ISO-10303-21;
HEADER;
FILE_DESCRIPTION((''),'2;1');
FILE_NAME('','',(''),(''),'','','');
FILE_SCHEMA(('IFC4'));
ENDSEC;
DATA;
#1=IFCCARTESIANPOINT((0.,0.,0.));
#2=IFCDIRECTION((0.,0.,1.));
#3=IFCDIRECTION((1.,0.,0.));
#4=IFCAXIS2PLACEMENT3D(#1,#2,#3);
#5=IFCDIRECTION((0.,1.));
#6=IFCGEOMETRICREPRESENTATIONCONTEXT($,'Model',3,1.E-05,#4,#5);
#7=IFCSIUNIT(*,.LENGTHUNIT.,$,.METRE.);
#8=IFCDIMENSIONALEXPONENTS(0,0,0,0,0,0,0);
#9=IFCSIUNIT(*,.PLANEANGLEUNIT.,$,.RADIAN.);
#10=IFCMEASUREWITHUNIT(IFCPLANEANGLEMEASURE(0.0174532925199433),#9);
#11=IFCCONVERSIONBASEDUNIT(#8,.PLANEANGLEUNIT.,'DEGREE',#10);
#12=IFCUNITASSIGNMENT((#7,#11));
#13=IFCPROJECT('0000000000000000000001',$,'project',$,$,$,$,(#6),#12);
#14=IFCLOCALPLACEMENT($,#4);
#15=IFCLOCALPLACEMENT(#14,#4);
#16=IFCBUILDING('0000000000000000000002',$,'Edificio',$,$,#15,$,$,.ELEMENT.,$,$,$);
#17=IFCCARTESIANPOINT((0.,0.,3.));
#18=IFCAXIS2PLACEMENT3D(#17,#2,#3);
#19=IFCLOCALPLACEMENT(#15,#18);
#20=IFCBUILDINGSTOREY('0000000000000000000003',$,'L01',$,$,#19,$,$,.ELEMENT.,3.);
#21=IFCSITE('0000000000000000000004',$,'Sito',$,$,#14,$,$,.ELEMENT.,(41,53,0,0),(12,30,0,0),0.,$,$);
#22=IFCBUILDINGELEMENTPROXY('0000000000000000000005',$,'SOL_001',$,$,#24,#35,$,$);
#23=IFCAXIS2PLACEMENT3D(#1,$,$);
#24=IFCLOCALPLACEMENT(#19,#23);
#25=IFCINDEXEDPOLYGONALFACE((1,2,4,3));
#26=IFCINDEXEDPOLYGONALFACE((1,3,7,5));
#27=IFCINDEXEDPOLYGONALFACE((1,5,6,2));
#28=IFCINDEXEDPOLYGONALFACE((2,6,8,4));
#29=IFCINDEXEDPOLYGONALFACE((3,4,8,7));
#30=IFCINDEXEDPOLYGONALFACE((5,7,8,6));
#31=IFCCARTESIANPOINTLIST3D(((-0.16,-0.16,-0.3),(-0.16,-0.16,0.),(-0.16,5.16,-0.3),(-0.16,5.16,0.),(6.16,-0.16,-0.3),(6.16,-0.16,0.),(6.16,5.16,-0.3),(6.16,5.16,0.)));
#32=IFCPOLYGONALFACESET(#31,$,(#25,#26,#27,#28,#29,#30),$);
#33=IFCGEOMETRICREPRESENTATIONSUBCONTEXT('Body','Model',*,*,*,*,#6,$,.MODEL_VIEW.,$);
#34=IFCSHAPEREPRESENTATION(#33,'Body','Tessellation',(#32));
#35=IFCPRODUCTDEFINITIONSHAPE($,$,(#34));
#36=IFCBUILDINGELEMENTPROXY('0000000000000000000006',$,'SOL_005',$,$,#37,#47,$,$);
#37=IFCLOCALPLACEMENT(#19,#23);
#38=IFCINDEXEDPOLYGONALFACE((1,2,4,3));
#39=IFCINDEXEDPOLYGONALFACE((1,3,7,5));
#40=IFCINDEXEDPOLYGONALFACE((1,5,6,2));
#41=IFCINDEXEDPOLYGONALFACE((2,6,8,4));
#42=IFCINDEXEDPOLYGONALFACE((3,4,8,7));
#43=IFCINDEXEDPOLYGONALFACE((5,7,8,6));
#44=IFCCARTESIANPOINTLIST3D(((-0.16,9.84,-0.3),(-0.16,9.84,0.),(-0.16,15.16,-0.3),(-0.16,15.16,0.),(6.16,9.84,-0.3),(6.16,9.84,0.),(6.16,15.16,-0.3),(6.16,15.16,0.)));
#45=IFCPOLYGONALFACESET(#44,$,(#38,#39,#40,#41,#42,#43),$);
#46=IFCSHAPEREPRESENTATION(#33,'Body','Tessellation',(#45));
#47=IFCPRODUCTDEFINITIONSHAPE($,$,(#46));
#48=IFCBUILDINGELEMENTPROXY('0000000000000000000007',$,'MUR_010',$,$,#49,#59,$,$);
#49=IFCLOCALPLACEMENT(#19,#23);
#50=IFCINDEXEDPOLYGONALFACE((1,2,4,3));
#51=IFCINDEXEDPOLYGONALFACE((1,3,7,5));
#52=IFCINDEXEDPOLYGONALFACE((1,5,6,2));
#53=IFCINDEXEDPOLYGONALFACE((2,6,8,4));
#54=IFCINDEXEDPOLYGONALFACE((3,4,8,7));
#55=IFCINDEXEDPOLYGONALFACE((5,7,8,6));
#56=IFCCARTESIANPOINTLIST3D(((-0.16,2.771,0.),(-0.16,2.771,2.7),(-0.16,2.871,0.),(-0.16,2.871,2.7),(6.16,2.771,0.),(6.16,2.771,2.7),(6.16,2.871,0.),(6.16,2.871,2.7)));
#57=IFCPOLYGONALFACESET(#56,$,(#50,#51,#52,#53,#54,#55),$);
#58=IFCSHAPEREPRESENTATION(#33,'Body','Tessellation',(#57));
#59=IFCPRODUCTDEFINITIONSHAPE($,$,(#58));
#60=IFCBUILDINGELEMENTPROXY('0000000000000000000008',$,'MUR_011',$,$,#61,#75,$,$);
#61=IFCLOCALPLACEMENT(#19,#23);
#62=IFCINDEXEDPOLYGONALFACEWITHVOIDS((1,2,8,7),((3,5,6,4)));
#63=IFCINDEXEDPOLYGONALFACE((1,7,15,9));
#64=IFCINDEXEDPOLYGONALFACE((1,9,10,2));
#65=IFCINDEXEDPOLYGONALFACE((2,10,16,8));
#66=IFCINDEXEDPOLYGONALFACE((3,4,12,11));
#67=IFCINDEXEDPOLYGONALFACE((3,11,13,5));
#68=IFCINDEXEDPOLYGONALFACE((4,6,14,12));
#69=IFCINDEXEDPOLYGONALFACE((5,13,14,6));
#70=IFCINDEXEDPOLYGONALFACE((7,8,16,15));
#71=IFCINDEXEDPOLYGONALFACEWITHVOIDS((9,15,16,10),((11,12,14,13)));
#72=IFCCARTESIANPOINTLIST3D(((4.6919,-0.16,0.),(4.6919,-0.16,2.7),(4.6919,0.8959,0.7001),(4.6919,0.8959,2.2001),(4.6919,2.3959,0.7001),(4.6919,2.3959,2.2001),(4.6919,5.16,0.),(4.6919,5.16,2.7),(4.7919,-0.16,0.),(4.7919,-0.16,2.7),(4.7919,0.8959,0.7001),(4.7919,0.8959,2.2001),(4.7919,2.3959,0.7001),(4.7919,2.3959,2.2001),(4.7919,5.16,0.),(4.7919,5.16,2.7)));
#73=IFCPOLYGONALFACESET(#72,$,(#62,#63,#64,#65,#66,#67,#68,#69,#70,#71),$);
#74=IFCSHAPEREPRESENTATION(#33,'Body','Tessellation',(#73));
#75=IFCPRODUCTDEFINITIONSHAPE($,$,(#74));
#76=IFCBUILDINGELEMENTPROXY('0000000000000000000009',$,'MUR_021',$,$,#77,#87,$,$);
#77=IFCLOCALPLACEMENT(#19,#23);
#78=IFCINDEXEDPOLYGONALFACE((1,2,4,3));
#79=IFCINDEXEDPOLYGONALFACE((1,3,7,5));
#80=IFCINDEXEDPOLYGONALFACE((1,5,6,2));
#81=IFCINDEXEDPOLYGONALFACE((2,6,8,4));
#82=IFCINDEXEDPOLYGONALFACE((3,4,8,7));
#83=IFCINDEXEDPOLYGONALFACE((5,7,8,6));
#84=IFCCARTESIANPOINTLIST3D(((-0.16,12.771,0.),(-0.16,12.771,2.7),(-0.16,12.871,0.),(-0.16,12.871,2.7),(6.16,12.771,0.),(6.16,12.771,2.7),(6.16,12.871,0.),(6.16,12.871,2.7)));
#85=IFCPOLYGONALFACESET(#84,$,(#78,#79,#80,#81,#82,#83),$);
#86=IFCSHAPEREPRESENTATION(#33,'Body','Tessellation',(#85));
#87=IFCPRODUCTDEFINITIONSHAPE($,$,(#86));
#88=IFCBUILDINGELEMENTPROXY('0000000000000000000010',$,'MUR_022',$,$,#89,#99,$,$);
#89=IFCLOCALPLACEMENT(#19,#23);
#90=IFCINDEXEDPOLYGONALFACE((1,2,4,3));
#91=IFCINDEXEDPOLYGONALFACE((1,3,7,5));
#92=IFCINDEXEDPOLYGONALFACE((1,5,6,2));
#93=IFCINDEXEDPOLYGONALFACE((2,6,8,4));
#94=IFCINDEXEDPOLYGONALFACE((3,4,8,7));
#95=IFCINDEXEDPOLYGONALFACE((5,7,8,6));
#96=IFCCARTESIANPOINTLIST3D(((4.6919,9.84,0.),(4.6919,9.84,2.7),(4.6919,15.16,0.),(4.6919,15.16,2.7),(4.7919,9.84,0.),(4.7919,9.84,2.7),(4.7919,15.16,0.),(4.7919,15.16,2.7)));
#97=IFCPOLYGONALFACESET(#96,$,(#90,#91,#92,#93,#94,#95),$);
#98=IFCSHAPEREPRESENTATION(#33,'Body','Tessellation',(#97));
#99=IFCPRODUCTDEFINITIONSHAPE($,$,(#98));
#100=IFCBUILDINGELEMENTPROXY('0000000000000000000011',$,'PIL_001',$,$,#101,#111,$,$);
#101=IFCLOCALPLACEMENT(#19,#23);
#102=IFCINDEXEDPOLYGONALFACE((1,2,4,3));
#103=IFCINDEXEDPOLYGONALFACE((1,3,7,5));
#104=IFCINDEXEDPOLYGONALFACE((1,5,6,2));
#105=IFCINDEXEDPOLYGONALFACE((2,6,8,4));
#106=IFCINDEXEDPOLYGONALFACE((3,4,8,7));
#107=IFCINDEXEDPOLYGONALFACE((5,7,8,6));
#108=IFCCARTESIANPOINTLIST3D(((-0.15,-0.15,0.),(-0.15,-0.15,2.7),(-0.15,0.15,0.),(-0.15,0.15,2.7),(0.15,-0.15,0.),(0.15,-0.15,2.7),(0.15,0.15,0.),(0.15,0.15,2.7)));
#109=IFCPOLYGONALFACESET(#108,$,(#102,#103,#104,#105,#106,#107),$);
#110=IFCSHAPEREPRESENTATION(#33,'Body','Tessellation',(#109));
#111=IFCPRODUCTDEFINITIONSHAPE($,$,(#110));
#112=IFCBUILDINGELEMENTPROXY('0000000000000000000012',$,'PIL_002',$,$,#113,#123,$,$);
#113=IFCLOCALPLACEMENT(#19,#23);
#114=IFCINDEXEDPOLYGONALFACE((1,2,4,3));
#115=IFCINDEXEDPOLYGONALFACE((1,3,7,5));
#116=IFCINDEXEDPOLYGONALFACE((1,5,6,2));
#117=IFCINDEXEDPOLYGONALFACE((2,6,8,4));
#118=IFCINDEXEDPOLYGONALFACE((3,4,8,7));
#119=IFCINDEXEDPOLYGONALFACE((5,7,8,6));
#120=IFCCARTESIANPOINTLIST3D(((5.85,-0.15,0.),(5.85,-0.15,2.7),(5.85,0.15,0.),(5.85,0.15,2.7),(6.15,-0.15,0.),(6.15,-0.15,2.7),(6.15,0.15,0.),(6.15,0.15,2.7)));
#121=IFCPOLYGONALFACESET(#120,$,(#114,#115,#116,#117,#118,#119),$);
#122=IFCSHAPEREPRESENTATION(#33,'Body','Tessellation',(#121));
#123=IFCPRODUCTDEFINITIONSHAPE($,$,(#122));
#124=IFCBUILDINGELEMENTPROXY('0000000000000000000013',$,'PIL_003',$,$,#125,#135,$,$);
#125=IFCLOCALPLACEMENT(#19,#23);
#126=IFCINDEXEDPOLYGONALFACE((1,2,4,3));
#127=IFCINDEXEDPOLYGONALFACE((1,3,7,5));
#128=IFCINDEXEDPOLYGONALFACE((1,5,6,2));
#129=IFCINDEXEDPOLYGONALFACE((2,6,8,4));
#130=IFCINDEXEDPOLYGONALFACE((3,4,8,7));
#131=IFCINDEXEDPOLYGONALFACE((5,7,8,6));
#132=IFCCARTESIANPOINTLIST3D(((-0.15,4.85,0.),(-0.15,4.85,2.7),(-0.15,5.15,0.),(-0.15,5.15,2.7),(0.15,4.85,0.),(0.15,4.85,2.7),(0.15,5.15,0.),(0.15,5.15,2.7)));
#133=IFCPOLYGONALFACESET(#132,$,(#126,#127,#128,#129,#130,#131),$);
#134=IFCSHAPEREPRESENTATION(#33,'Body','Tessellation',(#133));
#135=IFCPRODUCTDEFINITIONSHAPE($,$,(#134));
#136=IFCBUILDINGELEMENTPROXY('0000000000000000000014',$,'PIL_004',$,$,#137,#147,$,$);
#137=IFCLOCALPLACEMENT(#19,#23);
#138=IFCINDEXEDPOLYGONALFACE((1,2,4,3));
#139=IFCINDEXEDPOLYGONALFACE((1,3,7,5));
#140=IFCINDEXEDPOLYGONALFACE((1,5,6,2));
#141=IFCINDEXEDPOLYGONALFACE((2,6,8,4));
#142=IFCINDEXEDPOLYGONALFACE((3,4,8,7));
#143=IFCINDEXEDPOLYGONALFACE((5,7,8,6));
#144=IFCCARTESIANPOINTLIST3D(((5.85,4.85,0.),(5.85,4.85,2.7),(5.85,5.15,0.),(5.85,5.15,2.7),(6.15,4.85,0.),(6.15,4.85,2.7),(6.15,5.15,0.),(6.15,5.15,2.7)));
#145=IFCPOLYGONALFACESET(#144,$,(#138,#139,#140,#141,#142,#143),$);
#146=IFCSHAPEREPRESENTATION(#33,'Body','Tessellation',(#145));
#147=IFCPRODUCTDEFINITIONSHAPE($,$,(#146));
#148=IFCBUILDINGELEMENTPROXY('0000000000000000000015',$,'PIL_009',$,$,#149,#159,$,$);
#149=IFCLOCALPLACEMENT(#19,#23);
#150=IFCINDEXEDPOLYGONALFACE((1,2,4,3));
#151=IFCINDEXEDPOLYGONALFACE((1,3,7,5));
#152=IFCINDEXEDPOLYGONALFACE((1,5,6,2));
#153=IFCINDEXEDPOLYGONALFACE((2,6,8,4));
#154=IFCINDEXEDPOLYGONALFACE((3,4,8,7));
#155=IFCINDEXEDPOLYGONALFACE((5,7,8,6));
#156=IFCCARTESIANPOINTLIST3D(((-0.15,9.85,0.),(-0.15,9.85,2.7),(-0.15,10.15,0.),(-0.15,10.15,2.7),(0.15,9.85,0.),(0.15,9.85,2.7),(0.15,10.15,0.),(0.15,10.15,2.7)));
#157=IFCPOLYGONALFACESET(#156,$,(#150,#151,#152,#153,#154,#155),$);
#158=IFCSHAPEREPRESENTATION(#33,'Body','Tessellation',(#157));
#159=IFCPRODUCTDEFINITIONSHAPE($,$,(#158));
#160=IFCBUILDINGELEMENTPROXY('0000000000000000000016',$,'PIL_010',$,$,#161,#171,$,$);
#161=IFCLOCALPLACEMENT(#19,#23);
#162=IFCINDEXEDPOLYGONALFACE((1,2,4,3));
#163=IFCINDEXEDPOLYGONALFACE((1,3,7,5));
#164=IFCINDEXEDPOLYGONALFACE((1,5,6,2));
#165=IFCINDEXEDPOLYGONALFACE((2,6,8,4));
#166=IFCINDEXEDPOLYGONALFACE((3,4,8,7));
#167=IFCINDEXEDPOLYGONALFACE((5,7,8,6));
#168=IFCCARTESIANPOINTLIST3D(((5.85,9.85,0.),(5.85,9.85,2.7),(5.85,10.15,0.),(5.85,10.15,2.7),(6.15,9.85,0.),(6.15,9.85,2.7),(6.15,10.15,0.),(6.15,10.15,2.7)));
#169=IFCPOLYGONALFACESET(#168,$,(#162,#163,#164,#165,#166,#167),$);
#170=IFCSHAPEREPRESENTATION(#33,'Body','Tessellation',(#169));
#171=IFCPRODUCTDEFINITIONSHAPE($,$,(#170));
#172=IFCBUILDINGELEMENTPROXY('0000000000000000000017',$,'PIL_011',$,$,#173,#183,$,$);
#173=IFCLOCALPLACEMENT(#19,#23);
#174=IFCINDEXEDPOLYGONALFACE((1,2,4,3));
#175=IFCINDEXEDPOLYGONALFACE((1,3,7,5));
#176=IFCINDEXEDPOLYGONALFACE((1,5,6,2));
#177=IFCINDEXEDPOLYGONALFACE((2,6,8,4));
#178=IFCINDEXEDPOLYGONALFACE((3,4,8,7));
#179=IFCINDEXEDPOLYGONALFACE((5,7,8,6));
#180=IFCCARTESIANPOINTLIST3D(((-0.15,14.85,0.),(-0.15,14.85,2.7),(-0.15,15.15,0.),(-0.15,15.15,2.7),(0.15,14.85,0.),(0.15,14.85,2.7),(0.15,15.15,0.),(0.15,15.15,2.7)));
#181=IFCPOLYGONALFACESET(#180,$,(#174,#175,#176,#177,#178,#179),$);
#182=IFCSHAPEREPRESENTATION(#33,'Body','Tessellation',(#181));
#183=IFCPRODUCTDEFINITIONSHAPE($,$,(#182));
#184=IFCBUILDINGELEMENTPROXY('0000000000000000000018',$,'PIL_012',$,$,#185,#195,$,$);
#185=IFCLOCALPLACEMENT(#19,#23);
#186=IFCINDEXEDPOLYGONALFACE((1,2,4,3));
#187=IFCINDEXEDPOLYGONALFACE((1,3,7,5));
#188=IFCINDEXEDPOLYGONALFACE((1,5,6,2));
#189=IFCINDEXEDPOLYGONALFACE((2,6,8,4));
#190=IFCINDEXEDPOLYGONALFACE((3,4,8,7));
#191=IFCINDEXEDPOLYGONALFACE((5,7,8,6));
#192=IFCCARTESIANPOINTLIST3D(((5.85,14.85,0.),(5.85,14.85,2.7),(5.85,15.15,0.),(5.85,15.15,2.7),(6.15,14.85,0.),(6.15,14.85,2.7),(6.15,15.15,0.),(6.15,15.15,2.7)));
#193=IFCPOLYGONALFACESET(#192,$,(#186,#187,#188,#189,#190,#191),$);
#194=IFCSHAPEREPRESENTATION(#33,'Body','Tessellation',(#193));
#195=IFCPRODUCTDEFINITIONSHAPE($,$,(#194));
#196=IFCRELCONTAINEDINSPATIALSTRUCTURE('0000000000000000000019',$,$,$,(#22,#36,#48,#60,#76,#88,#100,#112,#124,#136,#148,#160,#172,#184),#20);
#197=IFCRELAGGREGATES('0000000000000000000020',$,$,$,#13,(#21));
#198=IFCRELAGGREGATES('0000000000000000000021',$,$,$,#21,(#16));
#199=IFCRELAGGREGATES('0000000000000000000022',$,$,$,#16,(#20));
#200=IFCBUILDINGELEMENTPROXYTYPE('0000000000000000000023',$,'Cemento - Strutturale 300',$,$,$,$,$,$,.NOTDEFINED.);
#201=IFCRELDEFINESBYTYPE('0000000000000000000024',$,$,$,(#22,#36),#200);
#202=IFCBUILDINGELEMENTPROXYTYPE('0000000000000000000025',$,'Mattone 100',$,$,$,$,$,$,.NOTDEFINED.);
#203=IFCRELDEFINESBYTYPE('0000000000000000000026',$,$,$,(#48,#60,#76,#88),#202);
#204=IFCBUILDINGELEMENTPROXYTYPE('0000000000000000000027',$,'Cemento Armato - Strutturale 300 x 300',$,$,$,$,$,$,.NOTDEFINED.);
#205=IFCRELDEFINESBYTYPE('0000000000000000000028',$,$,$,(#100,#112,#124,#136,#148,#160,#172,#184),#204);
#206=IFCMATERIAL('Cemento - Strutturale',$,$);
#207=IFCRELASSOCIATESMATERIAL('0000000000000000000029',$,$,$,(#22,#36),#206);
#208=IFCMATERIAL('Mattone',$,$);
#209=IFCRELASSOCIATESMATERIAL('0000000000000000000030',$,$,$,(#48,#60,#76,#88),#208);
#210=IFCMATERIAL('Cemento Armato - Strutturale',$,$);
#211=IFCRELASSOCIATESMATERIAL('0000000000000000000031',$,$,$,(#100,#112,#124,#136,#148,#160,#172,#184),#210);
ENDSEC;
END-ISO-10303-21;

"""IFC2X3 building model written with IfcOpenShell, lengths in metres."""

from ifc_helpers import new_model, entity, si_unit, converted_unit, direction, frame, origin_with_axes, origin_2d_with_axis, place, context, subcontext, project, spatial, polyline, rectangle, outline, extrude, material, type_object, element, save


model = new_model("IFC2X3")

# Units and contexts
model_context = context("Model", 3, precision=1e-05, world=origin_with_axes(), true_north=direction((0.0, 1.0)))
body_context = subcontext(model_context, "Body", "Model", "MODEL_VIEW")
ifc_project = project(units=[si_unit("LENGTHUNIT", "METRE"), converted_unit("PLANEANGLEUNIT", "DEGREE", entity("IfcPlaneAngleMeasure", 0.0174532925199433), si_unit("PLANEANGLEUNIT", "RADIAN"), dimensions=[0, 0, 0, 0, 0, 0, 0])], contexts=[model_context])

# Site, building, storey
site_placement = place(None, origin_with_axes())
site = spatial("IfcSite", under=ifc_project, at=site_placement, Name="Sito", CompositionType="ELEMENT", RefLatitude=(41, 53, 0, 0), RefLongitude=(12, 30, 0, 0), RefElevation=0.0)
building_placement = place(site_placement, origin_with_axes())
building = spatial("IfcBuilding", under=site, at=building_placement, Name="Edificio", CompositionType="ELEMENT")
storey_placement = place(building_placement, frame((0.0, 0.0, 3.0), z_axis=(0.0, 0.0, 1.0), x_axis=(1.0, 0.0, 0.0)))
storey = spatial("IfcBuildingStorey", under=building, at=storey_placement, Name="L01", CompositionType="ELEMENT", Elevation=3.0)

# Building element proxies
ifc_material_1 = material(Name="Cemento - Strutturale")
building_element_proxy_type_1 = type_object("IfcBuildingElementProxyType", Name="Cemento - Strutturale 300", PredefinedType="NOTDEFINED")
for number, where, z_axis, x_axis, name in (
    (1, (-0.16, -0.16, 0.0), (0.0, 0.0, 1.0), (1.0, 0.0, 0.0), "SOL_001"),
    (2, (-0.16, 9.84, 0.0), (0.0, 0.0, 1.0), (1.0, 0.0, 0.0), "SOL_005"),
):
    element("IfcBuildingElementProxy", number, at=place(storey_placement, frame(where, z_axis=z_axis, x_axis=x_axis)), inside=storey, type_object=building_element_proxy_type_1, material=ifc_material_1, Name=name, context=body_context, shape_type="SweptSolid", body=[
        extrude(outline(polyline([(0.0, 0.0), (6.32, 0.0), (6.32, 5.32), (0.0, 5.32), (0.0, 0.0)])), frame((0.0, 0.0, -0.3), z_axis=(0.0, 0.0, 1.0), x_axis=(1.0, 0.0, 0.0)), (0.0, 0.0, 1.0), 0.3),
    ])
ifc_material_2 = material(Name="Mattone")
building_element_proxy_type_2 = type_object("IfcBuildingElementProxyType", Name="Mattone 100", PredefinedType="NOTDEFINED")
proxy_1_placement = place(storey_placement, frame((-0.16, 2.771, 0.0), z_axis=(0.0, 0.0, 1.0), x_axis=(1.0, 0.0, 0.0)))
element("IfcBuildingElementProxy", 3, at=proxy_1_placement, inside=storey, type_object=building_element_proxy_type_2, material=ifc_material_2, Name="MUR_010", context=body_context, shape_type="SweptSolid", body=[
    extrude(outline(polyline([(0.0, 0.0), (6.32, 0.0), (6.32, 0.1), (0.0, 0.1), (0.0, 0.0)])), origin_with_axes(), (0.0, 0.0, 1.0), 2.7),
])

# Building element proxy, opening
proxy_2_placement = place(storey_placement, frame((4.6919, 5.16, 0.0), z_axis=(0.0, 0.0, 1.0), x_axis=(0.0, -1.0, 0.0)))
proxy_2 = element("IfcBuildingElementProxy", 4, at=proxy_2_placement, inside=storey, type_object=building_element_proxy_type_2, material=ifc_material_2, Name="MUR_011", context=body_context, shape_type="SweptSolid", body=[
    extrude(outline(polyline([(0.0, 0.0), (5.32, 0.0), (5.32, 0.1), (0.0, 0.1), (0.0, 0.0)])), origin_with_axes(), (0.0, 0.0, 1.0), 2.7),
])
opening_placement = place(proxy_2_placement, frame((5.16, -4.6919, -3.0), z_axis=(0.0, 0.0, 1.0), x_axis=(0.0, 1.0, 0.0)))
element("IfcOpeningElement", 5, at=opening_placement, cuts=proxy_2, ObjectType="Empty Opening", context=body_context, shape_type="SweptSolid", body=[
    extrude(rectangle(XDim=1.5, YDim=1.5, at=origin_2d_with_axis()), frame((4.5919, 1.6459, 4.4501), z_axis=(-1.0, 0.0, 0.0), x_axis=(0.0, -1.0, 0.0)), (0.0, 0.0, -1.0), 0.3),
])

# Building element proxies
proxy_3_placement = place(storey_placement, frame((-0.16, 12.771, 0.0), z_axis=(0.0, 0.0, 1.0), x_axis=(1.0, 0.0, 0.0)))
element("IfcBuildingElementProxy", 6, at=proxy_3_placement, inside=storey, type_object=building_element_proxy_type_2, material=ifc_material_2, Name="MUR_021", context=body_context, shape_type="SweptSolid", body=[
    extrude(outline(polyline([(0.0, 0.0), (6.32, 0.0), (6.32, 0.1), (0.0, 0.1), (0.0, 0.0)])), origin_with_axes(), (0.0, 0.0, 1.0), 2.7),
])
proxy_4_placement = place(storey_placement, frame((4.6919, 15.16, 0.0), z_axis=(0.0, 0.0, 1.0), x_axis=(0.0, -1.0, 0.0)))
element("IfcBuildingElementProxy", 7, at=proxy_4_placement, inside=storey, type_object=building_element_proxy_type_2, material=ifc_material_2, Name="MUR_022", context=body_context, shape_type="SweptSolid", body=[
    extrude(outline(polyline([(0.0, 0.0), (5.32, 0.0), (5.32, 0.1), (0.0, 0.1), (0.0, 0.0)])), origin_with_axes(), (0.0, 0.0, 1.0), 2.7),
])
ifc_material_3 = material(Name="Cemento Armato - Strutturale")
building_element_proxy_type_3 = type_object("IfcBuildingElementProxyType", Name="Cemento Armato - Strutturale 300 x 300", PredefinedType="NOTDEFINED")
for number, where, z_axis, x_axis, name in (
    (8, (0.0, 0.0, 0.0), (0.0, 0.0, 1.0), (1.0, 0.0, 0.0), "PIL_001"),
    (9, (6.0, 0.0, 0.0), (0.0, 0.0, 1.0), (1.0, 0.0, 0.0), "PIL_002"),
    (10, (0.0, 5.0, 0.0), (0.0, 0.0, 1.0), (1.0, 0.0, 0.0), "PIL_003"),
    (11, (6.0, 5.0, 0.0), (0.0, 0.0, 1.0), (1.0, 0.0, 0.0), "PIL_004"),
    (12, (0.0, 10.0, 0.0), (0.0, 0.0, 1.0), (1.0, 0.0, 0.0), "PIL_009"),
    (13, (6.0, 10.0, 0.0), (0.0, 0.0, 1.0), (1.0, 0.0, 0.0), "PIL_010"),
    (14, (0.0, 15.0, 0.0), (0.0, 0.0, 1.0), (1.0, 0.0, 0.0), "PIL_011"),
    (15, (6.0, 15.0, 0.0), (0.0, 0.0, 1.0), (1.0, 0.0, 0.0), "PIL_012"),
):
    element("IfcBuildingElementProxy", number, at=place(storey_placement, frame(where, z_axis=z_axis, x_axis=x_axis)), inside=storey, type_object=building_element_proxy_type_3, material=ifc_material_3, Name=name, context=body_context, shape_type="SweptSolid", body=[
        extrude(rectangle(XDim=0.3, YDim=0.3, at=origin_2d_with_axis()), origin_with_axes(), (0.0, 0.0, 1.0), 2.7),
    ])

save(model, "model.ifc")
